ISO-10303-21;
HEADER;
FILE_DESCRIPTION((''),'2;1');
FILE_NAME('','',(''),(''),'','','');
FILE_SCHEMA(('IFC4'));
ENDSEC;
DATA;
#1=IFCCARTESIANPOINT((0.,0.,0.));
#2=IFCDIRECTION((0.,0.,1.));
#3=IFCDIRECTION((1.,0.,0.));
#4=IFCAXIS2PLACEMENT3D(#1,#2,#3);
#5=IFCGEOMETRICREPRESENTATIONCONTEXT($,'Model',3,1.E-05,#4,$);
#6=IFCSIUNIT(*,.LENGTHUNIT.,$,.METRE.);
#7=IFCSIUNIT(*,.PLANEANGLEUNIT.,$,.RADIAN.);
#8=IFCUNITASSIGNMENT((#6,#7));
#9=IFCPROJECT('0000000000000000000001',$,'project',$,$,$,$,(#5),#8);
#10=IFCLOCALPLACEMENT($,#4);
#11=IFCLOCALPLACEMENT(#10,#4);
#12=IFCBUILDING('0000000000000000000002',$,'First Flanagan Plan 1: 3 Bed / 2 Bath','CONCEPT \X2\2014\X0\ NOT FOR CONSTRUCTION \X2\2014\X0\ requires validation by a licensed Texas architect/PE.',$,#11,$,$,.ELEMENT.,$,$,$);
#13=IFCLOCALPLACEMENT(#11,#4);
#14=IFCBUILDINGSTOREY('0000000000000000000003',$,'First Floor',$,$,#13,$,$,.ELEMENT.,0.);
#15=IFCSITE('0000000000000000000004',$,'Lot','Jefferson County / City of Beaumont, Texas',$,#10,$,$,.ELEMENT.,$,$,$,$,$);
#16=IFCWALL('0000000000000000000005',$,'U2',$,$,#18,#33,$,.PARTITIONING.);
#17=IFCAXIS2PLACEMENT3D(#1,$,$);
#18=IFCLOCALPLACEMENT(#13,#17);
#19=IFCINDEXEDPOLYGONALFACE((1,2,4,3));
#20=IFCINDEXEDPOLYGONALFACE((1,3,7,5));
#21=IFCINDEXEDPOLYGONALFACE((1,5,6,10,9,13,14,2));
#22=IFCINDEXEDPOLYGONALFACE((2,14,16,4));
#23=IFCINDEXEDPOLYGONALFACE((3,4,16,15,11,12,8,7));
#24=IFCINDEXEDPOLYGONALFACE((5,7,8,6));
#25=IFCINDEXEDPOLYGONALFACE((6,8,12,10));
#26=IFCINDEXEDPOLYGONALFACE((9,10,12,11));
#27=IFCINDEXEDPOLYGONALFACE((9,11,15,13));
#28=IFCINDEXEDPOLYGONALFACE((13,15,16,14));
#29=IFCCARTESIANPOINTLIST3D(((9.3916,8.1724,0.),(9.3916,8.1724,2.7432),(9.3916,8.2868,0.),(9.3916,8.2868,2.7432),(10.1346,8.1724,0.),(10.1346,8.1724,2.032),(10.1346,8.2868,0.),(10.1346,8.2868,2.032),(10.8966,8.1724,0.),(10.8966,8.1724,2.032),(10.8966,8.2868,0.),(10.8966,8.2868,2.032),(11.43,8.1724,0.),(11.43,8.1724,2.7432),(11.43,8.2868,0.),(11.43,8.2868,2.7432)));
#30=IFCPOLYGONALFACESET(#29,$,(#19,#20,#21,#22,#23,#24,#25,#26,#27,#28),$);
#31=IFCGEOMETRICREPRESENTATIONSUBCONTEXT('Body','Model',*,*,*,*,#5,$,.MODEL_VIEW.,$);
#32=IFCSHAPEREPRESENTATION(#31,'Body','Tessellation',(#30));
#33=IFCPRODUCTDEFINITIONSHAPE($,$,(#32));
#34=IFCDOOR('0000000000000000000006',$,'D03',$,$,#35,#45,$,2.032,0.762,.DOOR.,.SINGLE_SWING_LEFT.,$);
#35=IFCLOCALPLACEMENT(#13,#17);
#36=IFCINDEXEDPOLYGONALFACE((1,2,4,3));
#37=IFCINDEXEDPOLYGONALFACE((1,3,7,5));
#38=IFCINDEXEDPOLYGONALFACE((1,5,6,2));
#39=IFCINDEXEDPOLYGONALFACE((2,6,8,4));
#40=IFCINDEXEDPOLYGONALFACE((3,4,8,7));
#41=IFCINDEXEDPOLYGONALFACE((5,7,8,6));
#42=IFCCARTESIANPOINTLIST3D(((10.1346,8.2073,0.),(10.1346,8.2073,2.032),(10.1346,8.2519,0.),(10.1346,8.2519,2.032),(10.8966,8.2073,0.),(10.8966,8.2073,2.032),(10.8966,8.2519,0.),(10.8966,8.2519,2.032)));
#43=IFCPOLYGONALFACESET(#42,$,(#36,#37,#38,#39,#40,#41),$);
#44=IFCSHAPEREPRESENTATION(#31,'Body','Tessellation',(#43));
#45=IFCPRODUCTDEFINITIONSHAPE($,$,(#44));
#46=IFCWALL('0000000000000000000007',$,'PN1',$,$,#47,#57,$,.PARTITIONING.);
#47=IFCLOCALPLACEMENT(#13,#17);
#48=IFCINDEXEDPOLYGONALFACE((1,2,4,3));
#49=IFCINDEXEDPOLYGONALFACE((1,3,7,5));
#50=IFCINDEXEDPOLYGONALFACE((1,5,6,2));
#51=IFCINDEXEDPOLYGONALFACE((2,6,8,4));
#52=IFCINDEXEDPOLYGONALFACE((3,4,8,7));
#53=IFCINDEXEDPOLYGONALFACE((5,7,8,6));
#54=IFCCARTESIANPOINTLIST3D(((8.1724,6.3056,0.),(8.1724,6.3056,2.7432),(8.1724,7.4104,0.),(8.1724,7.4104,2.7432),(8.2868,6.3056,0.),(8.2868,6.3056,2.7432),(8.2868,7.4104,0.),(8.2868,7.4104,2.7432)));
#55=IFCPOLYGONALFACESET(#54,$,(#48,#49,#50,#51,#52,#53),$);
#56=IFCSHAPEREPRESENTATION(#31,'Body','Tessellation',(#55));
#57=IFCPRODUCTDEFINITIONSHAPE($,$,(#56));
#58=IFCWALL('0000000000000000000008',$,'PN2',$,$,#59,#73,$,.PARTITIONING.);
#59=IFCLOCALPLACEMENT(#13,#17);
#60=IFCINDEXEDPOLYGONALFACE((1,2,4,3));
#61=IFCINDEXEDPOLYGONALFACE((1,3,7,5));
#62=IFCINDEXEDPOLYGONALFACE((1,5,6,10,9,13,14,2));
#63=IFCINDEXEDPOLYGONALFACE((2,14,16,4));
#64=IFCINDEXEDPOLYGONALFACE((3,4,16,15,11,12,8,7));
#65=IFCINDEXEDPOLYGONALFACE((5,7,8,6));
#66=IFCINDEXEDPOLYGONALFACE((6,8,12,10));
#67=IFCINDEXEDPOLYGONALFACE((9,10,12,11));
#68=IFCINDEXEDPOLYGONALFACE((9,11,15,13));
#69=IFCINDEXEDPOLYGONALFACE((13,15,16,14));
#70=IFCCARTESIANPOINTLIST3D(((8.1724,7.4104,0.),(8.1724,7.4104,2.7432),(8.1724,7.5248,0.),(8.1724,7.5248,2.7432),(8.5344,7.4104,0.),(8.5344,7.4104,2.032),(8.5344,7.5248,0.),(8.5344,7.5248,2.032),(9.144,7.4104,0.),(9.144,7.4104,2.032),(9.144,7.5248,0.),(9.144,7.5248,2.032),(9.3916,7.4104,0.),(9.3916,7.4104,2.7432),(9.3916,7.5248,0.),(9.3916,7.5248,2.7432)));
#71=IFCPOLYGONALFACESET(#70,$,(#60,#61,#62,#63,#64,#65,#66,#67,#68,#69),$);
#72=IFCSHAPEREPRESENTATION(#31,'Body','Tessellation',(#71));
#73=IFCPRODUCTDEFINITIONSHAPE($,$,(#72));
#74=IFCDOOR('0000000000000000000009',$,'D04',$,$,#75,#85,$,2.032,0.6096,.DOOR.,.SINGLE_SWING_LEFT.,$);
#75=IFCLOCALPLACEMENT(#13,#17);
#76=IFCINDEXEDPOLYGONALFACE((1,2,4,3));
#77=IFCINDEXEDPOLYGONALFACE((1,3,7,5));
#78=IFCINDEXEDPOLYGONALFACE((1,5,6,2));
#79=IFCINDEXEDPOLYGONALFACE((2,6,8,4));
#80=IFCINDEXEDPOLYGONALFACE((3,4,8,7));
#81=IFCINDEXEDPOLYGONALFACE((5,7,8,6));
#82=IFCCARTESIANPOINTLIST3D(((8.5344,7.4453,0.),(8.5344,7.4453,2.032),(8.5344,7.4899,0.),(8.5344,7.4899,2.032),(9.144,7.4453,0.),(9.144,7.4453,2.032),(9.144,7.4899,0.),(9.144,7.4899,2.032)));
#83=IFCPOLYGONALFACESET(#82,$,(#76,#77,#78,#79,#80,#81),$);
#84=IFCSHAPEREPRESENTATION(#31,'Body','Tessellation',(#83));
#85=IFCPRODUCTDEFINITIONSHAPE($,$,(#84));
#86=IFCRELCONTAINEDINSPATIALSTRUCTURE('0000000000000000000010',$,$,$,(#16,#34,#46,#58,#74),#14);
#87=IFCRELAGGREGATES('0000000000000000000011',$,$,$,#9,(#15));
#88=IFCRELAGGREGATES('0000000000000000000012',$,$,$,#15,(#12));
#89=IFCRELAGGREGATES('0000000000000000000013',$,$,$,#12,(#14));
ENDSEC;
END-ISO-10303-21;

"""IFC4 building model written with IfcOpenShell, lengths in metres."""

from ifc_helpers import new_model, si_unit, frame, frame_2d, origin_with_axes, place, context, subcontext, project, spatial, rectangle, extrude, element, fill, save


model = new_model("IFC4")

# Units and contexts
model_context = context("Model", 3, precision=1e-05, world=origin_with_axes())
body_context = subcontext(model_context, "Body", "Model", "MODEL_VIEW")
ifc_project = project(units=[si_unit("LENGTHUNIT", "METRE"), si_unit("PLANEANGLEUNIT", "RADIAN")], contexts=[model_context])

# Site, building, storey
site_placement = place(None, origin_with_axes())
site = spatial("IfcSite", under=ifc_project, at=site_placement, Name="Lot", Description="Jefferson County / City of Beaumont, Texas", CompositionType="ELEMENT")
building_placement = place(site_placement, origin_with_axes())
building = spatial("IfcBuilding", under=site, at=building_placement, Name="First Flanagan Plan 1: 3 Bed / 2 Bath", Description="CONCEPT — NOT FOR CONSTRUCTION — requires validation by a licensed Texas architect/PE.", CompositionType="ELEMENT")
storey_placement = place(building_placement, origin_with_axes())
storey = spatial("IfcBuildingStorey", under=building, at=storey_placement, Name="First Floor", CompositionType="ELEMENT", Elevation=0.0)

# Wall, opening, door
wall_1_placement = place(storey_placement, frame((9.3917, 8.2296, 0.0), z_axis=(0.0, 0.0, 1.0), x_axis=(1.0, 0.0, 0.0)))
wall_1 = element("IfcWall", 1, at=wall_1_placement, inside=storey, Name="U2", PredefinedType="PARTITIONING", context=body_context, shape_type="SweptSolid", body=[
    extrude(rectangle(XDim=2.0383, YDim=0.1143, at=frame_2d((1.0192, 0.0), x_axis=(1.0, 0.0))), origin_with_axes(), (0.0, 0.0, 1.0), 2.7432),
])
opening_1_placement = place(wall_1_placement, frame((0.7429, 0.0, 0.0), z_axis=(0.0, 0.0, 1.0), x_axis=(1.0, 0.0, 0.0)))
opening_1 = element("IfcOpeningElement", 2, at=opening_1_placement, cuts=wall_1, PredefinedType="OPENING", context=body_context, shape_type="SweptSolid", body=[
    extrude(rectangle(XDim=0.762, YDim=0.1448, at=frame_2d((0.381, 0.0), x_axis=(1.0, 0.0))), origin_with_axes(), (0.0, 0.0, 1.0), 2.032),
])
door_1_placement = place(opening_1_placement, origin_with_axes())
door_1 = element("IfcDoor", 3, at=door_1_placement, inside=storey, Name="D03", OperationType="SINGLE_SWING_LEFT", OverallHeight=2.032, OverallWidth=0.762, PredefinedType="DOOR", context=body_context, shape_type="SweptSolid", body=[
    extrude(rectangle(XDim=0.762, YDim=0.0445, at=frame_2d((0.381, 0.0), x_axis=(1.0, 0.0))), origin_with_axes(), (0.0, 0.0, 1.0), 2.032),
])
fill(opening_1, door_1)

# Wall
wall_2_placement = place(storey_placement, frame((8.2296, 6.3056, 0.0), z_axis=(0.0, 0.0, 1.0), x_axis=(0.0, 1.0, 0.0)))
element("IfcWall", 4, at=wall_2_placement, inside=storey, Name="PN1", PredefinedType="PARTITIONING", context=body_context, shape_type="SweptSolid", body=[
    extrude(rectangle(XDim=1.1049, YDim=0.1143, at=frame_2d((0.5524, 0.0), x_axis=(1.0, 0.0))), origin_with_axes(), (0.0, 0.0, 1.0), 2.7432),
])

# Wall, opening, door
wall_3_placement = place(storey_placement, frame((8.1724, 7.4676, 0.0), z_axis=(0.0, 0.0, 1.0), x_axis=(1.0, 0.0, 0.0)))
wall_3 = element("IfcWall", 5, at=wall_3_placement, inside=storey, Name="PN2", PredefinedType="PARTITIONING", context=body_context, shape_type="SweptSolid", body=[
    extrude(rectangle(XDim=1.2192, YDim=0.1143, at=frame_2d((0.6096, 0.0), x_axis=(1.0, 0.0))), origin_with_axes(), (0.0, 0.0, 1.0), 2.7432),
])
opening_2_placement = place(wall_3_placement, frame((0.3619, 0.0, 0.0), z_axis=(0.0, 0.0, 1.0), x_axis=(1.0, 0.0, 0.0)))
opening_2 = element("IfcOpeningElement", 6, at=opening_2_placement, cuts=wall_3, PredefinedType="OPENING", context=body_context, shape_type="SweptSolid", body=[
    extrude(rectangle(XDim=0.6096, YDim=0.1448, at=frame_2d((0.3048, 0.0), x_axis=(1.0, 0.0))), origin_with_axes(), (0.0, 0.0, 1.0), 2.032),
])
door_2_placement = place(opening_2_placement, origin_with_axes())
door_2 = element("IfcDoor", 7, at=door_2_placement, inside=storey, Name="D04", OperationType="SINGLE_SWING_LEFT", OverallHeight=2.032, OverallWidth=0.6096, PredefinedType="DOOR", context=body_context, shape_type="SweptSolid", body=[
    extrude(rectangle(XDim=0.6096, YDim=0.0445, at=frame_2d((0.3048, 0.0), x_axis=(1.0, 0.0))), origin_with_axes(), (0.0, 0.0, 1.0), 2.032),
])
fill(opening_2, door_2)

save(model, "model.ifc")
